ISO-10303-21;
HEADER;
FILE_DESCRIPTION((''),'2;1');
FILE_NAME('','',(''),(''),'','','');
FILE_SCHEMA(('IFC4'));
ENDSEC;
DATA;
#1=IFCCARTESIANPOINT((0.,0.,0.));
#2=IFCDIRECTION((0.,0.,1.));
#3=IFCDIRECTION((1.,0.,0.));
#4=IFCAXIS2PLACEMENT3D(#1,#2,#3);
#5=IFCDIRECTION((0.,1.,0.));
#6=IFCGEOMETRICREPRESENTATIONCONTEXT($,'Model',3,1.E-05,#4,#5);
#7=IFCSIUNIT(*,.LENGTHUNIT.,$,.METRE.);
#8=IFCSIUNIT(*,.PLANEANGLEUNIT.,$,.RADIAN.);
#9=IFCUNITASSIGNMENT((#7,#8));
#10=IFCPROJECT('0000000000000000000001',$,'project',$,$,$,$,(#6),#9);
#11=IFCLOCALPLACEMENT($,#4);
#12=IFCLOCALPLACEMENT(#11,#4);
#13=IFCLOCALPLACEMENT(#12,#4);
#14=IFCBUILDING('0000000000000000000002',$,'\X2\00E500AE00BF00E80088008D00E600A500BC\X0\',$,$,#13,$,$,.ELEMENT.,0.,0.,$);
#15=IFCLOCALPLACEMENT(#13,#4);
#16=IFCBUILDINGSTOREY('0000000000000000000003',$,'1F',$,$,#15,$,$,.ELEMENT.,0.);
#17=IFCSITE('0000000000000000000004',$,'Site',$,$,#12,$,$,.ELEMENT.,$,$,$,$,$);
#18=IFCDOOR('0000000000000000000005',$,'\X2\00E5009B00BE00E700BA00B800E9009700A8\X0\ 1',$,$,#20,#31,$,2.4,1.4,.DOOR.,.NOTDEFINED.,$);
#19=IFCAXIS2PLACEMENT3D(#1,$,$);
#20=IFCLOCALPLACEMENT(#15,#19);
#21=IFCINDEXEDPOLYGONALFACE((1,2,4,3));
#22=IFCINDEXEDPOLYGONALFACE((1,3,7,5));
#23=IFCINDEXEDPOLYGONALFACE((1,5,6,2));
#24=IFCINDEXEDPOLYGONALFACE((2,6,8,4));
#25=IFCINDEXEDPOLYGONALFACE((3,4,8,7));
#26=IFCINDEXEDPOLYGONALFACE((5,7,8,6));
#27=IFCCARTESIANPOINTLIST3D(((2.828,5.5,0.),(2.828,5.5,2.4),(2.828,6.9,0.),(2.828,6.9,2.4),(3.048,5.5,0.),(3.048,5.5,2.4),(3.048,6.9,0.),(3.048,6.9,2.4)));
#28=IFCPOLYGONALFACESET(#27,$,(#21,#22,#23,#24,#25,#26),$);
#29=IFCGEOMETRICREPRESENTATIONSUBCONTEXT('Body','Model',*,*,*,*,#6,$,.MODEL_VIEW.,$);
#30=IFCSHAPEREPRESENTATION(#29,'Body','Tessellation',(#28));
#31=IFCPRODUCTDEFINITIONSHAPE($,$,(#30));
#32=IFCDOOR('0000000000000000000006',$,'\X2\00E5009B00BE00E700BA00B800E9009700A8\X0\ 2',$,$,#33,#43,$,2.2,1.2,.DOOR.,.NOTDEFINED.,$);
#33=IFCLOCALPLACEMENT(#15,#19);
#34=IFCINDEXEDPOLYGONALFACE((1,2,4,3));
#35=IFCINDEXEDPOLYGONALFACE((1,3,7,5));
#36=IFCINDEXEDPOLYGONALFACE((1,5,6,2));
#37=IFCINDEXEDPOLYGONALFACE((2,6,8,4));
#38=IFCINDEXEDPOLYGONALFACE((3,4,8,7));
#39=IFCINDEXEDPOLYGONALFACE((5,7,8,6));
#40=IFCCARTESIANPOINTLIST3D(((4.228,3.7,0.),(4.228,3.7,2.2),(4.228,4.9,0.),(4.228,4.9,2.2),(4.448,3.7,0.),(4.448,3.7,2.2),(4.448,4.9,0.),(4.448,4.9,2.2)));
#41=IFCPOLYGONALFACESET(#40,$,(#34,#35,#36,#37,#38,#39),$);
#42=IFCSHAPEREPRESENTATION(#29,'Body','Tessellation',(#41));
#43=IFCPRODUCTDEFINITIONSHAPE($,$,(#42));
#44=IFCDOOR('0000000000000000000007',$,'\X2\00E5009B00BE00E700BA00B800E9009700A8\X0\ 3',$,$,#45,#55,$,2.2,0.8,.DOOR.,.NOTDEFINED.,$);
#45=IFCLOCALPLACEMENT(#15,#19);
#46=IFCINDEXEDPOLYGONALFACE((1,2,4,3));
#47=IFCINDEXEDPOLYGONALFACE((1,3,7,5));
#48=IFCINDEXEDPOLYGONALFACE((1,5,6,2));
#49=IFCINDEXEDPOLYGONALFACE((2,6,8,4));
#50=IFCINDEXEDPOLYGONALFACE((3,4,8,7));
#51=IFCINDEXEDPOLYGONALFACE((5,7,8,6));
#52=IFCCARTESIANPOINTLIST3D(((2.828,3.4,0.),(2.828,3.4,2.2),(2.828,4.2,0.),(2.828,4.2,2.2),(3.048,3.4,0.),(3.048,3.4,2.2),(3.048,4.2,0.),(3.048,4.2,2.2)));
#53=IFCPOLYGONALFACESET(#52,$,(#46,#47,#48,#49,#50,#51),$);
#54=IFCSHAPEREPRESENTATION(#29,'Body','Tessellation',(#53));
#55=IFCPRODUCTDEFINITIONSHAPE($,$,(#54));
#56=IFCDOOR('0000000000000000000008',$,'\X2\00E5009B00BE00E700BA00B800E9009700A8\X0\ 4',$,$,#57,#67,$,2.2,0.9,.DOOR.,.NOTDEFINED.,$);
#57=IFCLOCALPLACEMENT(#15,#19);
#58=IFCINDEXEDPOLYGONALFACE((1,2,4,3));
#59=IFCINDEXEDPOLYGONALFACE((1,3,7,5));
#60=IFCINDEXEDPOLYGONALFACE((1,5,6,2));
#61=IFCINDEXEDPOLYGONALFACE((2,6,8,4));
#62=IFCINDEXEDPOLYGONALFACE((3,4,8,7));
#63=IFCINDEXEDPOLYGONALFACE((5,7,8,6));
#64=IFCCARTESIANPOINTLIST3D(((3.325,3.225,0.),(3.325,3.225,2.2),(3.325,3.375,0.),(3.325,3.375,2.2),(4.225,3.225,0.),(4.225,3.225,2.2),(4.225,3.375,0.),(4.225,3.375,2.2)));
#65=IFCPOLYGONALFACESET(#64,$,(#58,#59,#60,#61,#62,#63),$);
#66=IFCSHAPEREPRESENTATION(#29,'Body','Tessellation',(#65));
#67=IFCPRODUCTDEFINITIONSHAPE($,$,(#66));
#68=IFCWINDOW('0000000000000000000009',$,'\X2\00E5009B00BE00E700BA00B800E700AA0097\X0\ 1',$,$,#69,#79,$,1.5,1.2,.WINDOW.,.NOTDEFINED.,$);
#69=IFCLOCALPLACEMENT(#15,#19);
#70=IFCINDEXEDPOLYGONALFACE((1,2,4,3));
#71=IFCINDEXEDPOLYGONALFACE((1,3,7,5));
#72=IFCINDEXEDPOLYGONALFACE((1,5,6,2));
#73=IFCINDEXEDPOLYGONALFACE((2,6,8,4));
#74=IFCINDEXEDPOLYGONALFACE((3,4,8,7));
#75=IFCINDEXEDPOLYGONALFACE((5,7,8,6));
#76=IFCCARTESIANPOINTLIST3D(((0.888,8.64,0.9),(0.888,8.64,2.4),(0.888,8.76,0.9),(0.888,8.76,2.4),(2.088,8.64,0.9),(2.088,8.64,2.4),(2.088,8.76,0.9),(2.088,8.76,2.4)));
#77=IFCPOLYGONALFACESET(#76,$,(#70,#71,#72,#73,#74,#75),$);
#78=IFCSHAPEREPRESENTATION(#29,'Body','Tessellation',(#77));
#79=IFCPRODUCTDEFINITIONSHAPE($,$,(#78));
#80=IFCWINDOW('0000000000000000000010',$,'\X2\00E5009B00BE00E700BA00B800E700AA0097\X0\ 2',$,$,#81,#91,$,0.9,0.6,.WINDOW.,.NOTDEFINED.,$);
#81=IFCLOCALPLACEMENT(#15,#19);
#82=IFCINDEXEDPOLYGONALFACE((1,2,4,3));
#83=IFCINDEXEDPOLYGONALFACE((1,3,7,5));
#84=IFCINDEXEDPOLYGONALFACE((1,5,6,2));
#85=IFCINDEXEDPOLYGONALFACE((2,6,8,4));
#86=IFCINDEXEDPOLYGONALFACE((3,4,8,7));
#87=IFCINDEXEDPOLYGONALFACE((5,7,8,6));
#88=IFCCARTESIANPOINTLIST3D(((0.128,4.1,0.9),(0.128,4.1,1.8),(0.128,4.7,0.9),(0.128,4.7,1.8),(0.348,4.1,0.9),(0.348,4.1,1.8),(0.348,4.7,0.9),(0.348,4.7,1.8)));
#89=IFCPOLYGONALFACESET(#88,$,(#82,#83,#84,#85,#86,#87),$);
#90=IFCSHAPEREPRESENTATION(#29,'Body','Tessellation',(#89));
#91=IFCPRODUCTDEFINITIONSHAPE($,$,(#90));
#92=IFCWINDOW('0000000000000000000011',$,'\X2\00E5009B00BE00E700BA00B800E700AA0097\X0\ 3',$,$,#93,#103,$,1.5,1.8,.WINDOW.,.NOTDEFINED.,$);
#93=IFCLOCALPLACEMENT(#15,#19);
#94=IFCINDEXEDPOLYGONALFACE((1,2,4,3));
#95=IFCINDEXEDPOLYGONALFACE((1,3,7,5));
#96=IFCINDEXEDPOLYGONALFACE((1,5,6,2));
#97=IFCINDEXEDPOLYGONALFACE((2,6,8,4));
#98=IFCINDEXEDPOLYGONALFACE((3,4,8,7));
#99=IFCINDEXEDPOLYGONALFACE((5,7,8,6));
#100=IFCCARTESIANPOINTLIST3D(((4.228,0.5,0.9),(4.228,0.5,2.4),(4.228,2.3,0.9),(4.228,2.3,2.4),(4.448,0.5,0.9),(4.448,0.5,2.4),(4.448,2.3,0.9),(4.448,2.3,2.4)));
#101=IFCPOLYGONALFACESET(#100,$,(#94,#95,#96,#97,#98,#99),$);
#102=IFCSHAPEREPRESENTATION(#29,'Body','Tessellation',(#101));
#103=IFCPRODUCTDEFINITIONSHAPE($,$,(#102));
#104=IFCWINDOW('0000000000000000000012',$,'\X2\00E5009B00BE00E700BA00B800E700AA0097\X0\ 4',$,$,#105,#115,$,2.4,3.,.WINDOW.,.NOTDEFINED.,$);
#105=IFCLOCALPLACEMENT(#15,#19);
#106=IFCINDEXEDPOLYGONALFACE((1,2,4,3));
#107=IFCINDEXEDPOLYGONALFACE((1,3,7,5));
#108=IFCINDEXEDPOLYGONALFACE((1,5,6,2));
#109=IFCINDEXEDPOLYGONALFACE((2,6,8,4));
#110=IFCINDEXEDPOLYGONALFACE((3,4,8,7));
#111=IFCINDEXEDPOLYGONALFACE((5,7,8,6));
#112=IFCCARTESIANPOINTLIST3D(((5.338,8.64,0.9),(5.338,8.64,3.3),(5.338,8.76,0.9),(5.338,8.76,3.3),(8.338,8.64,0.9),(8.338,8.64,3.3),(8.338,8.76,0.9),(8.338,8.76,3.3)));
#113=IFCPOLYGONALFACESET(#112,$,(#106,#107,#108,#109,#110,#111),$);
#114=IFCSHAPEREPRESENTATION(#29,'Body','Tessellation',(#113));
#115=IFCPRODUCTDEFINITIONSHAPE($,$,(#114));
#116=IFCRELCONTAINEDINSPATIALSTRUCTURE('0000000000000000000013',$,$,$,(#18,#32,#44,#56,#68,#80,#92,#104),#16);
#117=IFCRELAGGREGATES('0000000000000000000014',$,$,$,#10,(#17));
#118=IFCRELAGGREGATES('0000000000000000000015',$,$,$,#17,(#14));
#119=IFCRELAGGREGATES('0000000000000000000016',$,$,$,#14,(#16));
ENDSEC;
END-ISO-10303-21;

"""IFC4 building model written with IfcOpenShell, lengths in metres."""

from ifc_helpers import new_model, si_unit, direction, frame, frame_2d, origin_with_axes, place, context, subcontext, project, spatial, rectangle, extrude, element, save


model = new_model("IFC4")

# Units and contexts
model_context = context("Model", 3, precision=1e-05, world=origin_with_axes(), true_north=direction((0.0, 1.0, 0.0)))
body_context = subcontext(model_context, "Body", "Model", "MODEL_VIEW")
ifc_project = project(units=[si_unit("LENGTHUNIT", "METRE"), si_unit("PLANEANGLEUNIT", "RADIAN")], contexts=[model_context])

# Site, building, storey
placement = place(None, origin_with_axes())
site_placement = place(placement, origin_with_axes())
site = spatial("IfcSite", under=ifc_project, at=site_placement, Name="Site", CompositionType="ELEMENT")
building_placement = place(site_placement, origin_with_axes())
building = spatial("IfcBuilding", under=site, at=building_placement, Name="å®¿è\u0088\u008dæ¥¼", CompositionType="ELEMENT", ElevationOfRefHeight=0.0, ElevationOfTerrain=0.0)
storey_placement = place(building_placement, origin_with_axes())
storey = spatial("IfcBuildingStorey", under=building, at=storey_placement, Name="1F", CompositionType="ELEMENT", Elevation=0.0)

# Doors
door_1_placement = place(storey_placement, frame((2.938, 6.2, 0.0), z_axis=(0.0, 0.0, 1.0), x_axis=(0.0, 1.0, 0.0)))
element("IfcDoor", 1, at=door_1_placement, inside=storey, Name="å\u009b¾çº¸é\u0097¨ 1", OperationType="NOTDEFINED", OverallHeight=2.4, OverallWidth=1.4, PredefinedType="DOOR", context=body_context, shape_type="SweptSolid", body=[
    extrude(rectangle(XDim=1.4, YDim=0.22, at=frame_2d((0.0, 0.0), x_axis=(1.0, 0.0, 0.0))), frame((0.0, 0.0, 0.0), z_axis=(0.0, 0.0, 1.0)), (0.0, 0.0, 1.0), 2.4),
])
door_2_placement = place(storey_placement, frame((4.338, 4.3, 0.0), z_axis=(0.0, 0.0, 1.0), x_axis=(0.0, 1.0, 0.0)))
element("IfcDoor", 2, at=door_2_placement, inside=storey, Name="å\u009b¾çº¸é\u0097¨ 2", OperationType="NOTDEFINED", OverallHeight=2.2, OverallWidth=1.2, PredefinedType="DOOR", context=body_context, shape_type="SweptSolid", body=[
    extrude(rectangle(XDim=1.2, YDim=0.22, at=frame_2d((0.0, 0.0), x_axis=(1.0, 0.0, 0.0))), frame((0.0, 0.0, 0.0), z_axis=(0.0, 0.0, 1.0)), (0.0, 0.0, 1.0), 2.2),
])
door_3_placement = place(storey_placement, frame((2.938, 3.8, 0.0), z_axis=(0.0, 0.0, 1.0), x_axis=(0.0, 1.0, 0.0)))
element("IfcDoor", 3, at=door_3_placement, inside=storey, Name="å\u009b¾çº¸é\u0097¨ 3", OperationType="NOTDEFINED", OverallHeight=2.2, OverallWidth=0.8, PredefinedType="DOOR", context=body_context, shape_type="SweptSolid", body=[
    extrude(rectangle(XDim=0.8, YDim=0.22, at=frame_2d((0.0, 0.0), x_axis=(1.0, 0.0, 0.0))), frame((0.0, 0.0, 0.0), z_axis=(0.0, 0.0, 1.0)), (0.0, 0.0, 1.0), 2.2),
])
door_4_placement = place(storey_placement, frame((3.775, 3.3, 0.0), z_axis=(0.0, 0.0, 1.0), x_axis=(1.0, 0.0, 0.0)))
element("IfcDoor", 4, at=door_4_placement, inside=storey, Name="å\u009b¾çº¸é\u0097¨ 4", OperationType="NOTDEFINED", OverallHeight=2.2, OverallWidth=0.9, PredefinedType="DOOR", context=body_context, shape_type="SweptSolid", body=[
    extrude(rectangle(XDim=0.9, YDim=0.15, at=frame_2d((0.0, 0.0), x_axis=(1.0, 0.0, 0.0))), frame((0.0, 0.0, 0.0), z_axis=(0.0, 0.0, 1.0)), (0.0, 0.0, 1.0), 2.2),
])

# Windows
window_1_placement = place(storey_placement, frame((1.488, 8.7, 0.9), z_axis=(0.0, 0.0, 1.0), x_axis=(1.0, 0.0, 0.0)))
element("IfcWindow", 5, at=window_1_placement, inside=storey, Name="å\u009b¾çº¸çª\u0097 1", OverallHeight=1.5, OverallWidth=1.2, PartitioningType="NOTDEFINED", PredefinedType="WINDOW", context=body_context, shape_type="SweptSolid", body=[
    extrude(rectangle(XDim=1.2, YDim=0.12, at=frame_2d((0.0, 0.0), x_axis=(1.0, 0.0, 0.0))), frame((0.0, 0.0, 0.0), z_axis=(0.0, 0.0, 1.0)), (0.0, 0.0, 1.0), 1.5),
])
window_2_placement = place(storey_placement, frame((0.238, 4.4, 0.9), z_axis=(0.0, 0.0, 1.0), x_axis=(0.0, 1.0, 0.0)))
element("IfcWindow", 6, at=window_2_placement, inside=storey, Name="å\u009b¾çº¸çª\u0097 2", OverallHeight=0.9, OverallWidth=0.6, PartitioningType="NOTDEFINED", PredefinedType="WINDOW", context=body_context, shape_type="SweptSolid", body=[
    extrude(rectangle(XDim=0.6, YDim=0.22, at=frame_2d((0.0, 0.0), x_axis=(1.0, 0.0, 0.0))), frame((0.0, 0.0, 0.0), z_axis=(0.0, 0.0, 1.0)), (0.0, 0.0, 1.0), 0.9),
])
window_3_placement = place(storey_placement, frame((4.338, 1.4, 0.9), z_axis=(0.0, 0.0, 1.0), x_axis=(0.0, 1.0, 0.0)))
element("IfcWindow", 7, at=window_3_placement, inside=storey, Name="å\u009b¾çº¸çª\u0097 3", OverallHeight=1.5, OverallWidth=1.8, PartitioningType="NOTDEFINED", PredefinedType="WINDOW", context=body_context, shape_type="SweptSolid", body=[
    extrude(rectangle(XDim=1.8, YDim=0.22, at=frame_2d((0.0, 0.0), x_axis=(1.0, 0.0, 0.0))), frame((0.0, 0.0, 0.0), z_axis=(0.0, 0.0, 1.0)), (0.0, 0.0, 1.0), 1.5),
])
window_4_placement = place(storey_placement, frame((6.838, 8.7, 0.9), z_axis=(0.0, 0.0, 1.0), x_axis=(-1.0, 0.0, 0.0)))
element("IfcWindow", 8, at=window_4_placement, inside=storey, Name="å\u009b¾çº¸çª\u0097 4", OverallHeight=2.4, OverallWidth=3.0, PartitioningType="NOTDEFINED", PredefinedType="WINDOW", context=body_context, shape_type="SweptSolid", body=[
    extrude(rectangle(XDim=3.0, YDim=0.12, at=frame_2d((0.0, 0.0), x_axis=(1.0, 0.0, 0.0))), frame((0.0, 0.0, 0.0), z_axis=(0.0, 0.0, 1.0)), (0.0, 0.0, 1.0), 2.4),
])

save(model, "model.ifc")
